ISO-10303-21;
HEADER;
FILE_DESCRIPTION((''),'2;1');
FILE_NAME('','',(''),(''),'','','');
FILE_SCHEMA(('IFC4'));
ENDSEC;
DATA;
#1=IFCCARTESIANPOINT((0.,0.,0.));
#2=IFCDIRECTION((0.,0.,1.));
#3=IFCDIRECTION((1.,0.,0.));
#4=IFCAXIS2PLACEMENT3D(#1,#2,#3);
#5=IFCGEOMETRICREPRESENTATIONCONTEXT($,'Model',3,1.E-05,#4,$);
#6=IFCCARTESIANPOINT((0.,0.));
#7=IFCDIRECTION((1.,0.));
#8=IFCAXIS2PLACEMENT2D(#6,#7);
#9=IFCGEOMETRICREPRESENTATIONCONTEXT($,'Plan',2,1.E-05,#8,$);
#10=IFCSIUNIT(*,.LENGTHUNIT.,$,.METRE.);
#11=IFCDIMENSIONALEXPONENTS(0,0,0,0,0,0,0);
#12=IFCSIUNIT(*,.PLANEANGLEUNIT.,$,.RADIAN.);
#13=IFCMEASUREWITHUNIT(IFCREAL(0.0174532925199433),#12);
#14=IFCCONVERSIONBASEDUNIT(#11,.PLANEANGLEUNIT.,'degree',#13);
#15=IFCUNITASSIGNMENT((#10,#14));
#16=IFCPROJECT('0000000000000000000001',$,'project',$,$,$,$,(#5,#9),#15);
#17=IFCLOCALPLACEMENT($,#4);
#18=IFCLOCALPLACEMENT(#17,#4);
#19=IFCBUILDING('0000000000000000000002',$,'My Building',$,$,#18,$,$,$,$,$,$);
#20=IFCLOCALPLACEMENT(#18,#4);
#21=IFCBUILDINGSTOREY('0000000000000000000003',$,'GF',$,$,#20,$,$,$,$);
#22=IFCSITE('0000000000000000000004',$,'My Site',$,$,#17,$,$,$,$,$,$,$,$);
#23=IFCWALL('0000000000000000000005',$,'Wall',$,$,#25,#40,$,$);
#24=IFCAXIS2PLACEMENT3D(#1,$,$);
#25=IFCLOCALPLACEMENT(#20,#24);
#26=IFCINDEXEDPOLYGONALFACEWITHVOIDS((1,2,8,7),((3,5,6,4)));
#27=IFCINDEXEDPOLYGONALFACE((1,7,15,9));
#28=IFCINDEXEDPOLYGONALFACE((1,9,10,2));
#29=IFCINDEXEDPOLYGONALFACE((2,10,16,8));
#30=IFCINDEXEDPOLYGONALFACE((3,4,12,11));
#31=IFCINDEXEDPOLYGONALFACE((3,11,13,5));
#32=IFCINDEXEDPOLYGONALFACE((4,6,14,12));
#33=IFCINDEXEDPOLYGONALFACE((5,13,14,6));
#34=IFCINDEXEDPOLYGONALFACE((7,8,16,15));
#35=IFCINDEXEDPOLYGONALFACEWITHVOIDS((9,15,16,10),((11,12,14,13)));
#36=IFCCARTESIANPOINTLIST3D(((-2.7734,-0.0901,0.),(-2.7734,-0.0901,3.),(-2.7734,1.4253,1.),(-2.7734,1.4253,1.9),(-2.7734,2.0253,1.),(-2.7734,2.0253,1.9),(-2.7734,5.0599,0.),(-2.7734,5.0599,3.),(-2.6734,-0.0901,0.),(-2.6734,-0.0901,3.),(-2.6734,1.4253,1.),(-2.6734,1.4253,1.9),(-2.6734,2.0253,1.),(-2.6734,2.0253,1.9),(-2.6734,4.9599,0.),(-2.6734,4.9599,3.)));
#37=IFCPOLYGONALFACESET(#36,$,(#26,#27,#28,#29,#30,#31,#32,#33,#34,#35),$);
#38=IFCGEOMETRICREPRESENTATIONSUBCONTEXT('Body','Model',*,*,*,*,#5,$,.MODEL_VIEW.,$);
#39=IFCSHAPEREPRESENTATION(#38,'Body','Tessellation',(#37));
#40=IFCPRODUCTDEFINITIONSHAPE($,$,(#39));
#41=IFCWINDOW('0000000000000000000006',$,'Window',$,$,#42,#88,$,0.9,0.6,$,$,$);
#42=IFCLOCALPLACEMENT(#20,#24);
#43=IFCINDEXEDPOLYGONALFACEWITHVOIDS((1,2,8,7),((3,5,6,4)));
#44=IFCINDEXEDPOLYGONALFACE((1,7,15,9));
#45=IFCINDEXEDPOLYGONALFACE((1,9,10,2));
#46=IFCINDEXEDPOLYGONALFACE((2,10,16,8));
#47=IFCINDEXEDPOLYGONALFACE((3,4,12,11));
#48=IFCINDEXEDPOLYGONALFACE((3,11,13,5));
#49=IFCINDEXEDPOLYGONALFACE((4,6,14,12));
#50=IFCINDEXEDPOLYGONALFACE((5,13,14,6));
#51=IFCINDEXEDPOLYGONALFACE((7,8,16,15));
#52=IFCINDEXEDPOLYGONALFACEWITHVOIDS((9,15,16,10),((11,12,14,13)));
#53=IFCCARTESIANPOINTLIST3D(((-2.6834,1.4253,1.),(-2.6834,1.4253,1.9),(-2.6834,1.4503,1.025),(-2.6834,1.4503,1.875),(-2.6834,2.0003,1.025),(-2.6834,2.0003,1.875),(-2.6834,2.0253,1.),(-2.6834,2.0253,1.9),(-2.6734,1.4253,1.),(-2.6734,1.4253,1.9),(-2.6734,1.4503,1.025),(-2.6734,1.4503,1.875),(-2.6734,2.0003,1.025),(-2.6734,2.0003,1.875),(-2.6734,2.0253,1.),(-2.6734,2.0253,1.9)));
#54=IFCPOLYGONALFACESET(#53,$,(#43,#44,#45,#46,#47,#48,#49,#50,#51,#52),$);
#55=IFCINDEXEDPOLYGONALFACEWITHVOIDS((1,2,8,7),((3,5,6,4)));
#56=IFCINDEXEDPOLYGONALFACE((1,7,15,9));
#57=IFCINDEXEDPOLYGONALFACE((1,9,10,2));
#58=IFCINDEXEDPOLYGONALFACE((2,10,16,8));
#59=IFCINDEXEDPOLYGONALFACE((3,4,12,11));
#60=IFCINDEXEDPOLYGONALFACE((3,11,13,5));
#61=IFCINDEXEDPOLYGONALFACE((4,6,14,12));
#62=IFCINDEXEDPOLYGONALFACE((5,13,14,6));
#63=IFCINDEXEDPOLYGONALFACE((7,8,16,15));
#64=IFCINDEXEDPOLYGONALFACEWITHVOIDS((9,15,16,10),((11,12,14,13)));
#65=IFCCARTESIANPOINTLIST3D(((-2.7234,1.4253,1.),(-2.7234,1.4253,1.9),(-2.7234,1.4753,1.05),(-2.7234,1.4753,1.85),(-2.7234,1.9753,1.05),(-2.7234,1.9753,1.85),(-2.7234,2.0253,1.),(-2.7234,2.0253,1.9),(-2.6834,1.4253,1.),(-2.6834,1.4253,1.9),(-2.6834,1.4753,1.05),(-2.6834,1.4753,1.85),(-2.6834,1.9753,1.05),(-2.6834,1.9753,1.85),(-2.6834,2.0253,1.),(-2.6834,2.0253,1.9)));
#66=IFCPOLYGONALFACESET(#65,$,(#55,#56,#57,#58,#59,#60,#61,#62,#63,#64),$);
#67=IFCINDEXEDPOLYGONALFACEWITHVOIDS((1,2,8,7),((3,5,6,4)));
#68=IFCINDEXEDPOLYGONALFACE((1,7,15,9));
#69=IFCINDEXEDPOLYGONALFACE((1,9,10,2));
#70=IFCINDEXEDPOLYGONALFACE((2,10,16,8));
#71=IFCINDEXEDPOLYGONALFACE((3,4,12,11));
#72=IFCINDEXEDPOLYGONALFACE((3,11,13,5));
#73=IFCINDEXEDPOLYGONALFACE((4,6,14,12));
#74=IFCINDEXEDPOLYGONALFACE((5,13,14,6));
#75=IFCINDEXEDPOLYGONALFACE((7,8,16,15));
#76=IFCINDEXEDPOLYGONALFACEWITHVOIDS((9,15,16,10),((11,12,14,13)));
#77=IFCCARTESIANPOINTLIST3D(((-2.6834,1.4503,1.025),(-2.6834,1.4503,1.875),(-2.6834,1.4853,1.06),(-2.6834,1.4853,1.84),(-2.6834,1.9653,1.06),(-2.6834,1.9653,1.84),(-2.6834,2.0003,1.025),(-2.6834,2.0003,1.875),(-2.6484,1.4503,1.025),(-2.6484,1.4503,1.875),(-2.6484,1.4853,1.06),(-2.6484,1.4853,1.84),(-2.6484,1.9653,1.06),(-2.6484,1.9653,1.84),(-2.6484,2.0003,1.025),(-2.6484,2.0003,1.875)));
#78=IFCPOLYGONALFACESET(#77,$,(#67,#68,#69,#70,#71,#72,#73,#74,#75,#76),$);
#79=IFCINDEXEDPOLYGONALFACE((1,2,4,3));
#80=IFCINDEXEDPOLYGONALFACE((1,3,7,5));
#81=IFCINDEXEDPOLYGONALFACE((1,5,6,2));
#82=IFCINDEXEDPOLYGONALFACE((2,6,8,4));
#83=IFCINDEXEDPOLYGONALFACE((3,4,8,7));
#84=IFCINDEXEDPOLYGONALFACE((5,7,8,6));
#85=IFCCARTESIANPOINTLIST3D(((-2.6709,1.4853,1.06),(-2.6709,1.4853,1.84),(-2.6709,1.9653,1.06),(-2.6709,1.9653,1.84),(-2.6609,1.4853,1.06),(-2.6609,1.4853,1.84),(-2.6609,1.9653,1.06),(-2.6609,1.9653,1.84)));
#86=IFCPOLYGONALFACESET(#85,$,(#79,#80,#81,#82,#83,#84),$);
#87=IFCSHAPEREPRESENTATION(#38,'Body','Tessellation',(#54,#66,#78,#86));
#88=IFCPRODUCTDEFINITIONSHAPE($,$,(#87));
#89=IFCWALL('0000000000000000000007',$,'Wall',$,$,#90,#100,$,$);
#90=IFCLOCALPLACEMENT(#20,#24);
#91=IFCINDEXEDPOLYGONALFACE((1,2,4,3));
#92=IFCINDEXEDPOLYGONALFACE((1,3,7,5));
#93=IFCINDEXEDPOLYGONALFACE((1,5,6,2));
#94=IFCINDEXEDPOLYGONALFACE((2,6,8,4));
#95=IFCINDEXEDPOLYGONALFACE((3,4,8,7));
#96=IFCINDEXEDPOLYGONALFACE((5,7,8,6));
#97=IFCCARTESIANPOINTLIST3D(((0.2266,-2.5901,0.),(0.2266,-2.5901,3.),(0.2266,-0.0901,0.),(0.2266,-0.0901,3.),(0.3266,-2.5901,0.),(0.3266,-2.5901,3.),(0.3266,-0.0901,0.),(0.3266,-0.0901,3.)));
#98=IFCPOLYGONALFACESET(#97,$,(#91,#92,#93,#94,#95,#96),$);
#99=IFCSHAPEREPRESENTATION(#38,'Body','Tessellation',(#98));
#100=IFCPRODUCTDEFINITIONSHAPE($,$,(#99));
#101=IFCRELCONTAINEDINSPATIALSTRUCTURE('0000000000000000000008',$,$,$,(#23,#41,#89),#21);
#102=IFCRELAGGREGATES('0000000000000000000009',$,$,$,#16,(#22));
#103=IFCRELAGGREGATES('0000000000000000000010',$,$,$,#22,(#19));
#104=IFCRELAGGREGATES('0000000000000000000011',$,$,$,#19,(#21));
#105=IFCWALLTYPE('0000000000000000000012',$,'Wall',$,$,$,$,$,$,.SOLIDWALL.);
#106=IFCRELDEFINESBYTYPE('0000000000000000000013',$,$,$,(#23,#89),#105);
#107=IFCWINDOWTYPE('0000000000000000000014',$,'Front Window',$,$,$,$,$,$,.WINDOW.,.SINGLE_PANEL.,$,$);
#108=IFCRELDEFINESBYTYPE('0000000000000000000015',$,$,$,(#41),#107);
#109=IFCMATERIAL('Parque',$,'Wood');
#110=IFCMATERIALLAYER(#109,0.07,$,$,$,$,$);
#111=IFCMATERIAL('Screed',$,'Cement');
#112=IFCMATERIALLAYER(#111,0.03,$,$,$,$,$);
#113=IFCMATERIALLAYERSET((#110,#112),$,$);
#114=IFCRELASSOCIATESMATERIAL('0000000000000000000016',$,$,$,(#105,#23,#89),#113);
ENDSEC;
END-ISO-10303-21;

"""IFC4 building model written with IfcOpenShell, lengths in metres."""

from ifc_helpers import new_model, entity, si_unit, converted_unit, frame, origin_with_axes, origin_2d_with_axis, place, context, subcontext, project, spatial, line, indexed_curve, outline, extrude, shape, source, transform, mapped, material, layer, layer_set, layer_usage, type_object, type_shapes, element, fill, save


model = new_model("IFC4")

# Units and contexts
model_context = context("Model", 3, precision=1e-05, world=origin_with_axes())
plan_context = context("Plan", 2, precision=1e-05, world=origin_2d_with_axis())
body_context_1 = subcontext(model_context, "Body", "Model", "MODEL_VIEW")
body_context_2 = subcontext(plan_context, "Body", "Plan", "PLAN_VIEW")
ifc_project = project(units=[si_unit("LENGTHUNIT", "METRE"), converted_unit("PLANEANGLEUNIT", "degree", entity("IfcReal", 0.0174532925199433), si_unit("PLANEANGLEUNIT", "RADIAN"), dimensions=[0, 0, 0, 0, 0, 0, 0])], contexts=[model_context, plan_context])

# Site, building, storey
site_placement = place(None, origin_with_axes())
site = spatial("IfcSite", under=ifc_project, at=site_placement, Name="My Site")
building_placement = place(site_placement, origin_with_axes())
building = spatial("IfcBuilding", under=site, at=building_placement, Name="My Building")
storey_placement = place(building_placement, origin_with_axes())
storey = spatial("IfcBuildingStorey", under=building, at=storey_placement, Name="GF")

# Shared definitions
ifc_material_1 = material(Name="Parque", Category="Wood")
ifc_layer_1 = layer(ifc_material_1, 0.07)
ifc_material_2 = material(Name="Screed", Category="Cement")
ifc_layer_2 = layer(ifc_material_2, 0.03)
ifc_layer_set_1 = layer_set([ifc_layer_1, ifc_layer_2])
wall_type = type_object("IfcWallType", Name="Wall", PredefinedType="SOLIDWALL", material=ifc_layer_set_1)
shared_shape_1 = source(origin_with_axes(), body_context_1, "Body", "SweptSolid", [
    extrude(outline(indexed_curve([(0.0, 0.0), (0.6, 0.0), (0.6, 0.9), (0.0, 0.9)], segments=[line(1, 2, 3, 4, 1)])), frame((0.0, -0.6, 0.0), z_axis=(0.0, -1.0, 0.0), x_axis=(1.0, 0.0, 0.0)), (0.0, 0.0, -1.0), 1.2),
])
window_type_1 = type_object("IfcWindowType", Name="Front Window", PartitioningType="SINGLE_PANEL", PredefinedType="WINDOW")
shared_shape_2 = source(origin_with_axes(), body_context_1, "Body", "SweptSolid", [
    extrude(outline(indexed_curve([(0.0, 0.0), (0.6, 0.0), (0.6, 0.9), (0.0, 0.9)], segments=[line(1, 2, 3, 4, 1)]), holes=[indexed_curve([(0.025, 0.025), (0.575, 0.025), (0.575, 0.875), (0.025, 0.875)], segments=[line(1, 2, 3, 4, 1)])]), frame((0.0, 0.09, 0.0), z_axis=(0.0, -1.0, 0.0), x_axis=(1.0, 0.0, 0.0)), (0.0, 0.0, -1.0), 0.01),
    extrude(outline(indexed_curve([(0.0, 0.0), (0.6, 0.0), (0.6, 0.9), (0.0, 0.9)], segments=[line(1, 2, 3, 4, 1)]), holes=[indexed_curve([(0.05, 0.05), (0.55, 0.05), (0.55, 0.85), (0.05, 0.85)], segments=[line(1, 2, 3, 4, 1)])]), frame((0.0, 0.05, 0.0), z_axis=(0.0, -1.0, 0.0), x_axis=(1.0, 0.0, 0.0)), (0.0, 0.0, -1.0), 0.04),
    extrude(outline(indexed_curve([(0.0, 0.0), (0.55, 0.0), (0.55, 0.85), (0.0, 0.85)], segments=[line(1, 2, 3, 4, 1)]), holes=[indexed_curve([(0.035, 0.035), (0.515, 0.035), (0.515, 0.815), (0.035, 0.815)], segments=[line(1, 2, 3, 4, 1)])]), frame((0.025, 0.09, 0.025), z_axis=(0.0, -1.0, 0.0), x_axis=(1.0, 0.0, 0.0)), (0.0, 0.0, -1.0), 0.035),
    extrude(outline(indexed_curve([(0.035, 0.035), (0.515, 0.035), (0.515, 0.815), (0.035, 0.815)], segments=[line(1, 2, 3, 4, 1)])), frame((0.025, 0.1025, 0.025), z_axis=(0.0, -1.0, 0.0), x_axis=(1.0, 0.0, 0.0)), (0.0, 0.0, -1.0), 0.01),
])
shared_shape_3 = source(origin_with_axes(), body_context_2, "Body", "Curve2D", [
    entity("IfcIndexedPolyCurve", entity("IfcCartesianPointList2D", [[0.05, 0.05], [0.55, 0.05]])),
    entity("IfcIndexedPolyCurve", entity("IfcCartesianPointList2D", [[0.0, 0.1], [0.025, 0.1], [0.025, 0.09], [0.05, 0.09], [0.05, 0.05], [0.0, 0.05]]), [entity("IfcLineIndex", [1, 2, 3, 4, 5, 6, 1])]),
    entity("IfcIndexedPolyCurve", entity("IfcCartesianPointList2D", [[0.6, 0.1], [0.575, 0.1], [0.575, 0.09], [0.55, 0.09], [0.55, 0.05], [0.6, 0.05]]), [entity("IfcLineIndex", [1, 2, 3, 4, 5, 6, 1])]),
    entity("IfcIndexedPolyCurve", entity("IfcCartesianPointList2D", [[0.025, 0.09], [0.06, 0.09], [0.06, 0.125], [0.025, 0.125]]), [entity("IfcLineIndex", [1, 2, 3, 4, 1])]),
    entity("IfcIndexedPolyCurve", entity("IfcCartesianPointList2D", [[0.575, 0.09], [0.54, 0.09], [0.54, 0.125], [0.575, 0.125]]), [entity("IfcLineIndex", [1, 2, 3, 4, 1])]),
    entity("IfcIndexedPolyCurve", entity("IfcCartesianPointList2D", [[0.06, 0.09], [0.54, 0.09]])),
    entity("IfcIndexedPolyCurve", entity("IfcCartesianPointList2D", [[0.06, 0.125], [0.54, 0.125]])),
    entity("IfcIndexedPolyCurve", entity("IfcCartesianPointList2D", [[0.06, 0.1075], [0.54, 0.1075]])),
])
type_shapes(window_type_1, [shared_shape_2, shared_shape_3])

# Wall, opening, window
ifc_layer_usage_1 = layer_usage(ifc_layer_set_1, "AXIS2", "POSITIVE", 0.0)
wall_1_placement = place(storey_placement, frame((-2.7734, 5.0599, 0.0), z_axis=(0.0, 0.0, 1.0), x_axis=(0.0, -1.0, 0.0)))
wall_1 = element("IfcWall", 1, at=wall_1_placement, inside=storey, type_object=wall_type, material=ifc_layer_usage_1, Name="Wall", context=body_context_1, shape_type="SweptSolid", body=[
    extrude(outline(indexed_curve([(0.0, 0.0), (0.1, 0.1), (5.15, 0.1), (5.15, 0.0)], segments=[line(1, 2, 3, 4, 1)])), origin_with_axes(), (0.0, 0.0, 1.0), 3.0),
])
opening_1_placement = place(wall_1_placement, frame((3.0346, 0.0, 1.0), z_axis=(0.0, 0.0, 1.0), x_axis=(1.0, 0.0, 0.0)))
opening_1 = element("IfcOpeningElement", 2, at=opening_1_placement, cuts=wall_1, PredefinedType="OPENING", context=body_context_1, shape_type="MappedRepresentation", body=[
    mapped(shared_shape_1, transform((0.0, 0.0, 0.0), x_axis=(1.0, 0.0, 0.0), y_axis=(0.0, 1.0, 0.0), z_axis=(0.0, 0.0, 1.0), scale=1.0)),
])
window_1_placement = place(opening_1_placement, frame((0.0, 0.0, 0.0), z_axis=(0.0, 0.0, 1.0), x_axis=(1.0, 0.0, 0.0)))
window_1 = element("IfcWindow", 3, at=window_1_placement, inside=storey, type_object=window_type_1, Name="Window", OverallHeight=0.9, OverallWidth=0.6, shapes=[
    shape(body_context_1, "Body", "MappedRepresentation", [mapped(shared_shape_2, transform((0.0, 0.0, 0.0), x_axis=(1.0, 0.0, 0.0), y_axis=(0.0, 1.0, 0.0), z_axis=(0.0, 0.0, 1.0), scale=1.0))]),
    shape(body_context_2, "Body", "MappedRepresentation", [mapped(shared_shape_3, transform((0.0, 0.0, 0.0), x_axis=(1.0, 0.0, 0.0), y_axis=(0.0, 1.0, 0.0), z_axis=(0.0, 0.0, 1.0), scale=1.0))]),
])
fill(opening_1, window_1)

# Wall
ifc_layer_usage_2 = layer_usage(ifc_layer_set_1, "AXIS2", "POSITIVE", 0.0)
wall_2_placement = place(storey_placement, frame((0.2266, -0.0901, 0.0), z_axis=(0.0, 0.0, 1.0), x_axis=(0.0, -1.0, 0.0)))
element("IfcWall", 4, at=wall_2_placement, inside=storey, type_object=wall_type, material=ifc_layer_usage_2, Name="Wall", context=body_context_1, shape_type="SweptSolid", body=[
    extrude(outline(indexed_curve([(0.0, 0.0), (0.0, 0.1), (2.5, 0.1), (2.5, 0.0)], segments=[line(1, 2, 3, 4, 1)])), origin_with_axes(), (0.0, 0.0, 1.0), 3.0),
])

save(model, "model.ifc")
